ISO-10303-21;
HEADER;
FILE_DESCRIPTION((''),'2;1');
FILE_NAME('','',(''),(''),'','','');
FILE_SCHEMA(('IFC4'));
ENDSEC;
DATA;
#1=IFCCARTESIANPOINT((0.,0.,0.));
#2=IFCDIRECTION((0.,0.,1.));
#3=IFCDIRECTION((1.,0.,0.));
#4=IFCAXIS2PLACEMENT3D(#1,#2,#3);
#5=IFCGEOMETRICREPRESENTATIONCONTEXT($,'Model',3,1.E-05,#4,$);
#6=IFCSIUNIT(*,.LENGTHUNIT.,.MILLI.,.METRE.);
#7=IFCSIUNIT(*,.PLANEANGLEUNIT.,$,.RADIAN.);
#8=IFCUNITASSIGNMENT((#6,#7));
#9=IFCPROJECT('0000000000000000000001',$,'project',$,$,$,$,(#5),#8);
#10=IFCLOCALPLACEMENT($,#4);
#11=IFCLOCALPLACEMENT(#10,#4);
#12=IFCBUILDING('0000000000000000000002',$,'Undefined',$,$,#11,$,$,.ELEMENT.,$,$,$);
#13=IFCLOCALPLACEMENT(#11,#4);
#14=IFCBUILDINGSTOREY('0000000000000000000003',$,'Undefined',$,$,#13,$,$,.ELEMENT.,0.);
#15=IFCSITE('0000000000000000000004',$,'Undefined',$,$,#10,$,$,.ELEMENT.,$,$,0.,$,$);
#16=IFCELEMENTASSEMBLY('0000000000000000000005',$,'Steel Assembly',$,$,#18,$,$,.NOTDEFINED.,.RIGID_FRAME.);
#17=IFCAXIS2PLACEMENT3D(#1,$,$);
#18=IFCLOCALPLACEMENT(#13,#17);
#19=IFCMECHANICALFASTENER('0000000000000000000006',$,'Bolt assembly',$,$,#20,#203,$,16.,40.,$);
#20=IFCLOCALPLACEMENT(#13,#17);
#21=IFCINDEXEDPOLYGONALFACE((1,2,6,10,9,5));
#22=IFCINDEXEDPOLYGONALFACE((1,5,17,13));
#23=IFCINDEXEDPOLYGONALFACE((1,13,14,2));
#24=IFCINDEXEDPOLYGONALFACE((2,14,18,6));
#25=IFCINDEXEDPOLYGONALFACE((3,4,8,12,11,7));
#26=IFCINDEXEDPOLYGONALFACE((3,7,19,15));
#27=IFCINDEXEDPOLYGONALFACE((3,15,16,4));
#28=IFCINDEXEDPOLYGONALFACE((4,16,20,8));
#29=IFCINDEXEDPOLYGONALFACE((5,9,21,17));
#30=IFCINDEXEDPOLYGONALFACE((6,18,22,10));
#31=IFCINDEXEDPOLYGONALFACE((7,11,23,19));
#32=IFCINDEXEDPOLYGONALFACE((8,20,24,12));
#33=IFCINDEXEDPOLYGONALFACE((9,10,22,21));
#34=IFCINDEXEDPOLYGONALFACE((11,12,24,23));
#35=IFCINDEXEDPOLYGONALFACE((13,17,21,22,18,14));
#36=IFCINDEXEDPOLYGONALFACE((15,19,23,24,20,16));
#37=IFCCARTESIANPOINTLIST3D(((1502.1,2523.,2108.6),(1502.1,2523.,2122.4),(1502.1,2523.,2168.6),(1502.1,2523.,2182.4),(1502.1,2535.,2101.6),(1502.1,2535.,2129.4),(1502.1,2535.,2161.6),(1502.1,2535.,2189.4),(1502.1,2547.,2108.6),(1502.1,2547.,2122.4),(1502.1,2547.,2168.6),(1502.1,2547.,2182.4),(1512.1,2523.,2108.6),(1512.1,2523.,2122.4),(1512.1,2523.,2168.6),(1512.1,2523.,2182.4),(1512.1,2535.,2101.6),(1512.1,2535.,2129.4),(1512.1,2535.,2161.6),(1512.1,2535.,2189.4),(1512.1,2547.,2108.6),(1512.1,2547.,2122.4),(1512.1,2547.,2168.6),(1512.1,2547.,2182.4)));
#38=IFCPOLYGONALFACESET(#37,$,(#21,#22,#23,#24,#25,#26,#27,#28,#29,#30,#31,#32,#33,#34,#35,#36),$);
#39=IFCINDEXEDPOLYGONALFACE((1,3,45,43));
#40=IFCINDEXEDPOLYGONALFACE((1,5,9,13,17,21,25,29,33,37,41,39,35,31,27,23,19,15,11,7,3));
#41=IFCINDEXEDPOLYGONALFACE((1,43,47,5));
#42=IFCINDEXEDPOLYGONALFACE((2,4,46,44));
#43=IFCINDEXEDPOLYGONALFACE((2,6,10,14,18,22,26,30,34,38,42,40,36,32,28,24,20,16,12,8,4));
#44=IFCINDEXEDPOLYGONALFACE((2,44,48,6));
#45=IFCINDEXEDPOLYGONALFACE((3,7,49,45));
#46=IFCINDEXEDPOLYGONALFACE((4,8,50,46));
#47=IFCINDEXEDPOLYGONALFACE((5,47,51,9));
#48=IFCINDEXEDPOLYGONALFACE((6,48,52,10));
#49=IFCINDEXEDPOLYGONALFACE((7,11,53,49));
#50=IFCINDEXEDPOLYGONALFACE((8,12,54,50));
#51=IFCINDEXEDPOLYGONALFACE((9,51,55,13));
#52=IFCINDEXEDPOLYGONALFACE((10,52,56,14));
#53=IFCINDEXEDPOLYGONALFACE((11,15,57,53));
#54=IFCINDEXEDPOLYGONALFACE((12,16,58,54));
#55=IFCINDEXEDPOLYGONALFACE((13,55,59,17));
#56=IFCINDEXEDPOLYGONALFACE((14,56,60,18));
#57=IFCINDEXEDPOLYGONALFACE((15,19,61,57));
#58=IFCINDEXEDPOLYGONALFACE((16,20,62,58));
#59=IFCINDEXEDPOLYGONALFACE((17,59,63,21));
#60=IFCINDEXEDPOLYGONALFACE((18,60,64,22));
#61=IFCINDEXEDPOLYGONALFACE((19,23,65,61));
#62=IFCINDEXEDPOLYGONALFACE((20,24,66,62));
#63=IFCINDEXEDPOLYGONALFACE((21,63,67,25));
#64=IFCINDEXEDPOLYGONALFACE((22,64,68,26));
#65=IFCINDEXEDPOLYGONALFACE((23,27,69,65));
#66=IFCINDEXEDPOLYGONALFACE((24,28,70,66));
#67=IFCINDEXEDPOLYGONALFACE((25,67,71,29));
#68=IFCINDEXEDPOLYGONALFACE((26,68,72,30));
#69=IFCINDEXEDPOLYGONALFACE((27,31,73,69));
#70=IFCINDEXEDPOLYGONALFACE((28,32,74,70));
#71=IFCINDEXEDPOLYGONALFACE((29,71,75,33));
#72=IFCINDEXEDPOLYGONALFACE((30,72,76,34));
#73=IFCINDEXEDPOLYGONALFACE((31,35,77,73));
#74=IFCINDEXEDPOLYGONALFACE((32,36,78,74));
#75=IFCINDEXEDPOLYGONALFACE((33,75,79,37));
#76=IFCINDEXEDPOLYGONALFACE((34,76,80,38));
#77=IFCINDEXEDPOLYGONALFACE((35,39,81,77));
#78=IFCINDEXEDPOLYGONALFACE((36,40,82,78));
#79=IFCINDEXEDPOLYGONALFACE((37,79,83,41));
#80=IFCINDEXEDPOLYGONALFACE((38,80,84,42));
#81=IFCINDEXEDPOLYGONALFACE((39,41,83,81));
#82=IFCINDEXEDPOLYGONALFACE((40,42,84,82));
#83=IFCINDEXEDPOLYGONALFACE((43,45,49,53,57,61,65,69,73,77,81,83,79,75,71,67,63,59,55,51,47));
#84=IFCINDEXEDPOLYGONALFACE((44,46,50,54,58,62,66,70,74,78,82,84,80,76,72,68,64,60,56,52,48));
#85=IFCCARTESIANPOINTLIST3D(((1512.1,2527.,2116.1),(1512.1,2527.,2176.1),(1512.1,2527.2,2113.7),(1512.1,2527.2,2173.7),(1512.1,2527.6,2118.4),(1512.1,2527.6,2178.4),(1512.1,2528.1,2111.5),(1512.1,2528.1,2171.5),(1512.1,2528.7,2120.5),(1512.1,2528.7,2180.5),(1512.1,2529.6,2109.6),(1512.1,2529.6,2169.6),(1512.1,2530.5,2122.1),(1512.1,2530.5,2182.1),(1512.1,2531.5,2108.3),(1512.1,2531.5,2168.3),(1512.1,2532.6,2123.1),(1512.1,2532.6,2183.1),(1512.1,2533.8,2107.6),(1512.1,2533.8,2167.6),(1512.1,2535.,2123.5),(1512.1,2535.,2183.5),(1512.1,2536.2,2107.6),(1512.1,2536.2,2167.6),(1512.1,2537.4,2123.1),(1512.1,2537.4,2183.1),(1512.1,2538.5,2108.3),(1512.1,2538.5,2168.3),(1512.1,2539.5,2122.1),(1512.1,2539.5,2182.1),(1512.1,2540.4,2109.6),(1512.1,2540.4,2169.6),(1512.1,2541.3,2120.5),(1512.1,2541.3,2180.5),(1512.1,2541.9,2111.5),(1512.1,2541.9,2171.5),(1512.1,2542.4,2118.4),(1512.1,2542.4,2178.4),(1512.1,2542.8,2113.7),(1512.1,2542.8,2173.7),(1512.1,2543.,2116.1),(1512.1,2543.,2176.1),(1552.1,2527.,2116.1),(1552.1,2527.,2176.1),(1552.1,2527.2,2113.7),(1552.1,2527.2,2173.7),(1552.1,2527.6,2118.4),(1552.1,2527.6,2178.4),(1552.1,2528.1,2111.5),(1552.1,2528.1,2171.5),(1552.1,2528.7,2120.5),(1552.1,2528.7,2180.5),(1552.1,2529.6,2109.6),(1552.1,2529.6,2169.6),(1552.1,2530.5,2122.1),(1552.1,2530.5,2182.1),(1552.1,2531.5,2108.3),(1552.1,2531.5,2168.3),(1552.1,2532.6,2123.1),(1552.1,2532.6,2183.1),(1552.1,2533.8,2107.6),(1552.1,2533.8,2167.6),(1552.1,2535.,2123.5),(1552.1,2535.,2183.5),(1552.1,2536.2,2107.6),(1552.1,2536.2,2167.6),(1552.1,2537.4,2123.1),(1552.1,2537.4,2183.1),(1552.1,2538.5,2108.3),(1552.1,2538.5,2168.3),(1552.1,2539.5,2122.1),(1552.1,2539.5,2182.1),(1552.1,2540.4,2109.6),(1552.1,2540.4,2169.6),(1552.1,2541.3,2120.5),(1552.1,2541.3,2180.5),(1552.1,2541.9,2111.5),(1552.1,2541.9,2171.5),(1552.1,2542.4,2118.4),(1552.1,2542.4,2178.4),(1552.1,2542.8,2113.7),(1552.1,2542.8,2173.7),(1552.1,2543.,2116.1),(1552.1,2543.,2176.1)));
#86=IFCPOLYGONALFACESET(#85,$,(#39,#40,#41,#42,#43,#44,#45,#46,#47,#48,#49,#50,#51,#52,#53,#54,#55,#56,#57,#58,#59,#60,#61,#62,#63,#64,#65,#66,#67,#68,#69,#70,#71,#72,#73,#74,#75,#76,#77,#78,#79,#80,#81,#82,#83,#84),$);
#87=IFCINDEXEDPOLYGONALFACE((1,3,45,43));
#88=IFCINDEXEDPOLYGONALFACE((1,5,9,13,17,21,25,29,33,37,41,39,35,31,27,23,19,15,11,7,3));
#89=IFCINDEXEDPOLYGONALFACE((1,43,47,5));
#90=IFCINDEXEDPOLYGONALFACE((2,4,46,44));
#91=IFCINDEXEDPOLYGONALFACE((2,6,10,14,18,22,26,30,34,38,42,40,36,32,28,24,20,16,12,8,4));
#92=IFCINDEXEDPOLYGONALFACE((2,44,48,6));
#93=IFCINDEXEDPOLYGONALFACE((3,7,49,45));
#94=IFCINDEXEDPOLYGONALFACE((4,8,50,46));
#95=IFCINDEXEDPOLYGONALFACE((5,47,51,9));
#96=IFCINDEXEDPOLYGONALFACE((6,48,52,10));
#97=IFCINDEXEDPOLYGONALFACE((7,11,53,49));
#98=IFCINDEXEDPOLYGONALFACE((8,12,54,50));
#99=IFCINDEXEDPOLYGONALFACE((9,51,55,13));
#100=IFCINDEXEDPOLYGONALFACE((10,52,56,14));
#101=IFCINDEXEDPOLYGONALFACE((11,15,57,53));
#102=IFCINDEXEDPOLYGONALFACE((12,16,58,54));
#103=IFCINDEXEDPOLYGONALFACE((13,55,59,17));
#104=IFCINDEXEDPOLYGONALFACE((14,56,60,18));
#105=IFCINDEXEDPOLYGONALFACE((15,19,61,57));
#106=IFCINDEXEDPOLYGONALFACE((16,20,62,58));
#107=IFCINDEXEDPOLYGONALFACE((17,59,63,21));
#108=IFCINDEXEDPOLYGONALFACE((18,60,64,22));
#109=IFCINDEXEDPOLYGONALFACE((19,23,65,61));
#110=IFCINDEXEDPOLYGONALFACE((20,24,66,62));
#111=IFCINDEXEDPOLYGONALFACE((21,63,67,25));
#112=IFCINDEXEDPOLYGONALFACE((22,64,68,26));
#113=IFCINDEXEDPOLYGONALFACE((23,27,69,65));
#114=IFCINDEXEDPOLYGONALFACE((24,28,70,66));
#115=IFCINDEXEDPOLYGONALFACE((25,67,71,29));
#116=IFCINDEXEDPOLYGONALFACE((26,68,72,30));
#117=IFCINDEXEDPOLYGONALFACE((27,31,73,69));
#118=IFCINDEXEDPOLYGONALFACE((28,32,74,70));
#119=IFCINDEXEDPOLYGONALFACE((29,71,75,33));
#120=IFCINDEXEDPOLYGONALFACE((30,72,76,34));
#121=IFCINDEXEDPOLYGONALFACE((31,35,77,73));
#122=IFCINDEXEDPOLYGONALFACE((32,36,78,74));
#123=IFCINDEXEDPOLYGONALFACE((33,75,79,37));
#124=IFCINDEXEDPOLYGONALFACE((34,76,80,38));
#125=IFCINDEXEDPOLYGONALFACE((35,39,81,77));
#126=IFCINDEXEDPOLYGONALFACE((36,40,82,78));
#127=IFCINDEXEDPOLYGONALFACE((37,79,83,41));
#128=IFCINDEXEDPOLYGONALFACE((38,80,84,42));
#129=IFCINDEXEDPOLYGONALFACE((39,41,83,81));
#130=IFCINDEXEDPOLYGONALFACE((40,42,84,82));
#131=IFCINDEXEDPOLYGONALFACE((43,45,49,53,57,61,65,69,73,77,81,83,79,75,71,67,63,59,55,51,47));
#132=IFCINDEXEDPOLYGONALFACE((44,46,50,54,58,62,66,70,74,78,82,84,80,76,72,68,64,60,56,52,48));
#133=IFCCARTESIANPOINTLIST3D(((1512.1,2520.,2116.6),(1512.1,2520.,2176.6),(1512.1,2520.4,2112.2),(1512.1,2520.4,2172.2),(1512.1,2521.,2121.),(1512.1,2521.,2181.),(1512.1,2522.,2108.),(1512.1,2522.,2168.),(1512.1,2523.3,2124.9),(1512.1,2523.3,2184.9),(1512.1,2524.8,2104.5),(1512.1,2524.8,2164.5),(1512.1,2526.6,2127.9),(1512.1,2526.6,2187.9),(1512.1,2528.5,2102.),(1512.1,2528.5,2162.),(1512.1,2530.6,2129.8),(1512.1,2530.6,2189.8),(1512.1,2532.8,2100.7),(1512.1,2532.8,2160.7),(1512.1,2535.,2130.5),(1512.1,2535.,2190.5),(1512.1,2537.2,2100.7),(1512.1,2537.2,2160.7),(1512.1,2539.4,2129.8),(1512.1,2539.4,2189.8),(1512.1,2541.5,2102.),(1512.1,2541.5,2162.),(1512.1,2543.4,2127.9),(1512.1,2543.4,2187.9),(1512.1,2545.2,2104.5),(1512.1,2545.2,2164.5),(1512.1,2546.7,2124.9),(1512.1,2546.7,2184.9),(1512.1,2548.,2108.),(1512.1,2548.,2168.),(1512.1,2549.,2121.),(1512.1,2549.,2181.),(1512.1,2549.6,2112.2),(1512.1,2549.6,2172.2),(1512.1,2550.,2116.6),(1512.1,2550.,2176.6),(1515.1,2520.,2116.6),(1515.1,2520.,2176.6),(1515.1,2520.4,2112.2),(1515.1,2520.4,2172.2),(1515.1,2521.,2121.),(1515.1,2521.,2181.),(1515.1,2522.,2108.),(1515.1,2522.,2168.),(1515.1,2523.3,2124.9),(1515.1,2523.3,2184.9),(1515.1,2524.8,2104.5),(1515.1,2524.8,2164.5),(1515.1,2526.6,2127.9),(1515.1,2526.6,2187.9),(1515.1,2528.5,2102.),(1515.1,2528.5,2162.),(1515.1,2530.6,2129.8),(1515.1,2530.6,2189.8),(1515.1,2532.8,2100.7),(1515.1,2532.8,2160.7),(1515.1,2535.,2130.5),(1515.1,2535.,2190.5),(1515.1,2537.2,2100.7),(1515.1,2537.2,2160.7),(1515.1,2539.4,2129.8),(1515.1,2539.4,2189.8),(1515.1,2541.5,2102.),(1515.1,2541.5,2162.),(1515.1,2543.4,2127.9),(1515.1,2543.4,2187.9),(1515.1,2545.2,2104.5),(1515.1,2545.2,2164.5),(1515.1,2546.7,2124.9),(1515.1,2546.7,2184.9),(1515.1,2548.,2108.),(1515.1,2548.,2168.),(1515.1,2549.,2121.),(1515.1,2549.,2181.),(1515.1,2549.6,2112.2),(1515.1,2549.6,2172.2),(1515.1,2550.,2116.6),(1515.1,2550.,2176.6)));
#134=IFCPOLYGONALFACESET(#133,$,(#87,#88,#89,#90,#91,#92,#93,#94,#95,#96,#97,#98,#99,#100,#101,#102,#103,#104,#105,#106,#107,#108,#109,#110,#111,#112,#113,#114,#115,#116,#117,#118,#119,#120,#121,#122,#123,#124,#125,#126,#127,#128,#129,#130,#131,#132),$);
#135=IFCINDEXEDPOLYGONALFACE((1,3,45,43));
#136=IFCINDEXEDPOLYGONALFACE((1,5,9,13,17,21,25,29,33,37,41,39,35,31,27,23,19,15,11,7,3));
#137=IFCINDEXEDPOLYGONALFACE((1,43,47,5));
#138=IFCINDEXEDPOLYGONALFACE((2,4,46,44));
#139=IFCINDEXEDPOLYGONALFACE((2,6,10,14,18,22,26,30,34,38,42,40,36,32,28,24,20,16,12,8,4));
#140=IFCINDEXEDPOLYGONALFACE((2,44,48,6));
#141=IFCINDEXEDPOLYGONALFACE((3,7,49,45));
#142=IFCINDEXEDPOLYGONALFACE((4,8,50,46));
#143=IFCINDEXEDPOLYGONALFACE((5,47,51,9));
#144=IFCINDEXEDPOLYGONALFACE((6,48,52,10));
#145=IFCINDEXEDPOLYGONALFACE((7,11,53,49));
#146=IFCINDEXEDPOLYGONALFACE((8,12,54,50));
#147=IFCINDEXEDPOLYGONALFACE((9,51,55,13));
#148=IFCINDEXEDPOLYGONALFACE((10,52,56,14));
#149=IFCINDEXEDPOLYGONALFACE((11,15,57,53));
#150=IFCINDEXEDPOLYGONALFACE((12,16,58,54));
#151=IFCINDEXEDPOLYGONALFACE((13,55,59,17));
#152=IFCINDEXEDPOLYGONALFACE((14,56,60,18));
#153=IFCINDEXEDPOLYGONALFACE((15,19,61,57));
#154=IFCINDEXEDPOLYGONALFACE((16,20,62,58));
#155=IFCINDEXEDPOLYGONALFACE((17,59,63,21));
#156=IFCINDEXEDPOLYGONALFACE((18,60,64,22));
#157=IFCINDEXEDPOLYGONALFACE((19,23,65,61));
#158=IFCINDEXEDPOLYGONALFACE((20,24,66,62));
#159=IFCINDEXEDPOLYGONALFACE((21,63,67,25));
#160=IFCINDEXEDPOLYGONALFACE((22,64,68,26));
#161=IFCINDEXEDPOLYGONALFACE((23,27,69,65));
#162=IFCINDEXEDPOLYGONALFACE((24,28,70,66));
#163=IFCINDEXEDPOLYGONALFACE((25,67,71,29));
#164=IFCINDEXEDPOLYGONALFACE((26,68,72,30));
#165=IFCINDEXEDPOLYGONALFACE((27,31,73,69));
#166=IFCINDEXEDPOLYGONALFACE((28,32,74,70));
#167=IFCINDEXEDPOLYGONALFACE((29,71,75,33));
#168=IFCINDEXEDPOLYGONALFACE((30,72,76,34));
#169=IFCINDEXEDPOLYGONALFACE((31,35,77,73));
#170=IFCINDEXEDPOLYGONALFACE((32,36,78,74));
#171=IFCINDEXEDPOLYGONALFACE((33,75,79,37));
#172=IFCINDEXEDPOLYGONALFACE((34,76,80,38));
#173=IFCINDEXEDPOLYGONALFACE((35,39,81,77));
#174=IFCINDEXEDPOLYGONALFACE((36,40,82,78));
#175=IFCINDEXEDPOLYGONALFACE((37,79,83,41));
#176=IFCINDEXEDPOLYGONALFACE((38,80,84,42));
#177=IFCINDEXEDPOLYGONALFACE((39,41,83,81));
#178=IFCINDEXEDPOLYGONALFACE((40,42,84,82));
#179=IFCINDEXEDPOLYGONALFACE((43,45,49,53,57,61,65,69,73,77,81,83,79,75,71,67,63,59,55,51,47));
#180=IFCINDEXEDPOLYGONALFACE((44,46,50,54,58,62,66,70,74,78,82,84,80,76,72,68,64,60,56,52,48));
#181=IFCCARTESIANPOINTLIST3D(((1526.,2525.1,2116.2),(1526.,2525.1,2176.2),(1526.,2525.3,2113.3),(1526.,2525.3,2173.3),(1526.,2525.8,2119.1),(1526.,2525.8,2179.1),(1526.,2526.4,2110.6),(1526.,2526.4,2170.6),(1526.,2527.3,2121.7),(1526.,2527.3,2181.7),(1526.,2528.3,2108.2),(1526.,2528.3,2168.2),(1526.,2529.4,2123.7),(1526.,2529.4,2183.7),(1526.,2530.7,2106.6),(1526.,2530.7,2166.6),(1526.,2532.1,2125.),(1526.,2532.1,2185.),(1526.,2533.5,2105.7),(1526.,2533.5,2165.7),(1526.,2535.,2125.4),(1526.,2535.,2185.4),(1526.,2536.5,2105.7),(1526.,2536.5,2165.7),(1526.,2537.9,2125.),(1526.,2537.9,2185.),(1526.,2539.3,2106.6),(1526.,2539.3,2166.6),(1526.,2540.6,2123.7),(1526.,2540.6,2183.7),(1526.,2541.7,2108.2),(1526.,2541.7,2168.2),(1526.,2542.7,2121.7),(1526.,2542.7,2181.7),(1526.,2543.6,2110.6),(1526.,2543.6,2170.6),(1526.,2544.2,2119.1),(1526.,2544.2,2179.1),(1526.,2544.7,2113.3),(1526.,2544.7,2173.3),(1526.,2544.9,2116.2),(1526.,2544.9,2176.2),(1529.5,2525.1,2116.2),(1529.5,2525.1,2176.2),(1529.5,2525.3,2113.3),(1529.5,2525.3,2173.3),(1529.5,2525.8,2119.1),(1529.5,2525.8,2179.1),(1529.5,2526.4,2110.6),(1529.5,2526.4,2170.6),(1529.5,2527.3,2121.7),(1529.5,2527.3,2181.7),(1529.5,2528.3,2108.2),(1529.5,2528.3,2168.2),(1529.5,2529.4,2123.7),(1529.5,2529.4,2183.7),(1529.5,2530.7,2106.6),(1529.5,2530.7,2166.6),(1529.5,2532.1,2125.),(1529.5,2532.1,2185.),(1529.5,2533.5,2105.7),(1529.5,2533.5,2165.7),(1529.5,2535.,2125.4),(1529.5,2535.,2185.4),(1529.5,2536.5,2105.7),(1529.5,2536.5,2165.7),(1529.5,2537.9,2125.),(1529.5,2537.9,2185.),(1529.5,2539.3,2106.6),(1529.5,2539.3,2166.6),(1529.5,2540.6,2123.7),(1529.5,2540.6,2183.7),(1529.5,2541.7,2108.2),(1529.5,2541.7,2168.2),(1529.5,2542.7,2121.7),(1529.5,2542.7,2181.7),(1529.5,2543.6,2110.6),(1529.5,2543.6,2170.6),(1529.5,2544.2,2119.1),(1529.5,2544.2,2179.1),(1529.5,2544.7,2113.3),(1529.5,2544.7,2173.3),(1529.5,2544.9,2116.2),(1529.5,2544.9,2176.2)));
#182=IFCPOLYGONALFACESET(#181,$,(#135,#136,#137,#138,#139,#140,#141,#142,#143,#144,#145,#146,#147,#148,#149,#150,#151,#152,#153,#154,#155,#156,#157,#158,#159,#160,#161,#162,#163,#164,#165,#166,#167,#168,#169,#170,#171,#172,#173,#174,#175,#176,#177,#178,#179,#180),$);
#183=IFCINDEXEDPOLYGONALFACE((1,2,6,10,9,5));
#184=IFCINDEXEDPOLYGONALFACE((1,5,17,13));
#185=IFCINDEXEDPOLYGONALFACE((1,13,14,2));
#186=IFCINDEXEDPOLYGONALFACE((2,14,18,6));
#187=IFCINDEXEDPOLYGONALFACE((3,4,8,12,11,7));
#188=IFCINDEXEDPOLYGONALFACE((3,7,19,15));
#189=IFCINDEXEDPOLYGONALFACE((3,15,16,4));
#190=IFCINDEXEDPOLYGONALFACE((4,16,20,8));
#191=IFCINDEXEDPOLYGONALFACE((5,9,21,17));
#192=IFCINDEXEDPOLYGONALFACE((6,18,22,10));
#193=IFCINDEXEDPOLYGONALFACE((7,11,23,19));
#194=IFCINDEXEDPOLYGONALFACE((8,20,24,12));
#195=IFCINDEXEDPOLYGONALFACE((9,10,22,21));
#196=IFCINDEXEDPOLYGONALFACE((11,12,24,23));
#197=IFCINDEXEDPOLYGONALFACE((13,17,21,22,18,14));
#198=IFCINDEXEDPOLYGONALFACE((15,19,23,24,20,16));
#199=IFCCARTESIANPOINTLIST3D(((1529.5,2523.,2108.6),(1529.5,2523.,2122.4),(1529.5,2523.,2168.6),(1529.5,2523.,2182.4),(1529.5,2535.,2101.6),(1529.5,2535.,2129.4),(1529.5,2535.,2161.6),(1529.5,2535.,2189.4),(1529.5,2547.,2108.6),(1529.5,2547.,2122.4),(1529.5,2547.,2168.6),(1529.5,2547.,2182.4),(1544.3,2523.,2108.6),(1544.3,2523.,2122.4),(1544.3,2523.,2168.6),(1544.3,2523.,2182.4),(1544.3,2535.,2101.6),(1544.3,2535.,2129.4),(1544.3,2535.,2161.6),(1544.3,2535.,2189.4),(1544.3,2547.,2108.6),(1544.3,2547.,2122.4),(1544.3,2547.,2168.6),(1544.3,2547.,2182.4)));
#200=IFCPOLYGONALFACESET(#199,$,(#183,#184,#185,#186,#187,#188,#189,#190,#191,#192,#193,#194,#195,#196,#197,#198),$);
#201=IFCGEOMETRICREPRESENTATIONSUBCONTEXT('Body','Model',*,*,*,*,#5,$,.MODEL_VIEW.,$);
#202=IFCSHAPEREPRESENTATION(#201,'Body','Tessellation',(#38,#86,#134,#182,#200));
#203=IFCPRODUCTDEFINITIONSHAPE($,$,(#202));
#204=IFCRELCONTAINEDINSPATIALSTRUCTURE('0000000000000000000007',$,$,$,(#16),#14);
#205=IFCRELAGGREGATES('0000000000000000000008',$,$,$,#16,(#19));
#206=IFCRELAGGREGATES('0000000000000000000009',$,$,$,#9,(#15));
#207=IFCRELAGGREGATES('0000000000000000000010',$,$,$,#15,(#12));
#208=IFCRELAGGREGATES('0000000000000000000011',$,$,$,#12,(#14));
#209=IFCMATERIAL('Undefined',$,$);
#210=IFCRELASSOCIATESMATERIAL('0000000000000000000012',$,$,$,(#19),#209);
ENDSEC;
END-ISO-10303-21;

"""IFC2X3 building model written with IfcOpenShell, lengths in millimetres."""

from ifc_helpers import new_model, si_unit, frame, origin_with_axes, origin_2d_with_axis, place, context, subcontext, project, spatial, polyline, circle, outline, extrude, source, transform, mapped, material, element, aggregate, save


model = new_model("IFC2X3")

# Units and contexts
model_context = context("Model", 3, precision=1e-05, world=origin_with_axes())
body_context = subcontext(model_context, "Body", "Model", "MODEL_VIEW")
ifc_project = project(units=[si_unit("LENGTHUNIT", "METRE", prefix="MILLI"), si_unit("PLANEANGLEUNIT", "RADIAN")], contexts=[model_context])

# Site, building, storey
site_placement = place(None, origin_with_axes())
site = spatial("IfcSite", under=ifc_project, at=site_placement, Name="Undefined", CompositionType="ELEMENT", RefElevation=0.0)
building_placement = place(site_placement, origin_with_axes())
building = spatial("IfcBuilding", under=site, at=building_placement, Name="Undefined", CompositionType="ELEMENT")
storey_placement = place(building_placement, origin_with_axes())
storey = spatial("IfcBuildingStorey", under=building, at=storey_placement, Name="Undefined", CompositionType="ELEMENT", Elevation=0.0)

# Element assembly, mechanical fastener
assembly_1_placement = place(storey_placement, origin_with_axes())
assembly_1 = element("IfcElementAssembly", 1, at=assembly_1_placement, inside=storey, Name="Steel Assembly", AssemblyPlace="NOTDEFINED", PredefinedType="RIGID_FRAME")
ifc_material_1 = material(Name="Undefined")
shared_shape_1 = source(origin_with_axes(), body_context, "Body", "SweptSolid", [
    extrude(outline(polyline([(13.9, 0.0), (6.9, 12.0), (-6.9, 12.0), (-13.9, 0.0), (-6.9, -12.0), (6.9, -12.0), (13.9, 0.0)])), frame((0.0, -17.9, 0.0), z_axis=(0.0, 1.0, 0.0), x_axis=(1.0, 0.0, 0.0)), (0.0, 0.0, 1.0), 10.0),
    extrude(circle(Radius=8.0, at=origin_2d_with_axis()), frame((0.0, -7.9, 0.0), z_axis=(0.0, 1.0, 0.0), x_axis=(1.0, 0.0, 0.0)), (0.0, 0.0, 1.0), 40.0),
    extrude(circle(Radius=15.0, at=origin_2d_with_axis()), frame((0.0, -7.9, 0.0), z_axis=(0.0, 1.0, 0.0), x_axis=(1.0, 0.0, 0.0)), (0.0, 0.0, 1.0), 3.0),
    extrude(circle(Radius=9.9, at=origin_2d_with_axis()), frame((0.0, 6.0, 0.0), z_axis=(0.0, 1.0, 0.0), x_axis=(1.0, 0.0, 0.0)), (0.0, 0.0, 1.0), 3.5),
    extrude(outline(polyline([(13.9, 0.0), (6.9, 12.0), (-6.9, 12.0), (-13.9, 0.0), (-6.9, -12.0), (6.9, -12.0), (13.9, 0.0)])), frame((0.0, 9.5, 0.0), z_axis=(0.0, 1.0, 0.0), x_axis=(1.0, 0.0, 0.0)), (0.0, 0.0, 1.0), 14.8),
])
mechanical_fastener_1_placement = place(assembly_1_placement, frame((1520.0, 2535.0, 2115.5), z_axis=(0.0, 1.0, 0.0), x_axis=(0.0, 0.0, 1.0)))
mechanical_fastener_1 = element("IfcMechanicalFastener", 2, at=mechanical_fastener_1_placement, material=ifc_material_1, Name="Bolt assembly", NominalDiameter=16.0, NominalLength=40.0, context=body_context, shape_type="MappedRepresentation", body=[
    mapped(shared_shape_1, transform((0.0, 0.0, 0.0))),
    mapped(shared_shape_1, transform((60.0, 0.0, 0.0))),
])
aggregate(assembly_1, [mechanical_fastener_1])

save(model, "model.ifc")
